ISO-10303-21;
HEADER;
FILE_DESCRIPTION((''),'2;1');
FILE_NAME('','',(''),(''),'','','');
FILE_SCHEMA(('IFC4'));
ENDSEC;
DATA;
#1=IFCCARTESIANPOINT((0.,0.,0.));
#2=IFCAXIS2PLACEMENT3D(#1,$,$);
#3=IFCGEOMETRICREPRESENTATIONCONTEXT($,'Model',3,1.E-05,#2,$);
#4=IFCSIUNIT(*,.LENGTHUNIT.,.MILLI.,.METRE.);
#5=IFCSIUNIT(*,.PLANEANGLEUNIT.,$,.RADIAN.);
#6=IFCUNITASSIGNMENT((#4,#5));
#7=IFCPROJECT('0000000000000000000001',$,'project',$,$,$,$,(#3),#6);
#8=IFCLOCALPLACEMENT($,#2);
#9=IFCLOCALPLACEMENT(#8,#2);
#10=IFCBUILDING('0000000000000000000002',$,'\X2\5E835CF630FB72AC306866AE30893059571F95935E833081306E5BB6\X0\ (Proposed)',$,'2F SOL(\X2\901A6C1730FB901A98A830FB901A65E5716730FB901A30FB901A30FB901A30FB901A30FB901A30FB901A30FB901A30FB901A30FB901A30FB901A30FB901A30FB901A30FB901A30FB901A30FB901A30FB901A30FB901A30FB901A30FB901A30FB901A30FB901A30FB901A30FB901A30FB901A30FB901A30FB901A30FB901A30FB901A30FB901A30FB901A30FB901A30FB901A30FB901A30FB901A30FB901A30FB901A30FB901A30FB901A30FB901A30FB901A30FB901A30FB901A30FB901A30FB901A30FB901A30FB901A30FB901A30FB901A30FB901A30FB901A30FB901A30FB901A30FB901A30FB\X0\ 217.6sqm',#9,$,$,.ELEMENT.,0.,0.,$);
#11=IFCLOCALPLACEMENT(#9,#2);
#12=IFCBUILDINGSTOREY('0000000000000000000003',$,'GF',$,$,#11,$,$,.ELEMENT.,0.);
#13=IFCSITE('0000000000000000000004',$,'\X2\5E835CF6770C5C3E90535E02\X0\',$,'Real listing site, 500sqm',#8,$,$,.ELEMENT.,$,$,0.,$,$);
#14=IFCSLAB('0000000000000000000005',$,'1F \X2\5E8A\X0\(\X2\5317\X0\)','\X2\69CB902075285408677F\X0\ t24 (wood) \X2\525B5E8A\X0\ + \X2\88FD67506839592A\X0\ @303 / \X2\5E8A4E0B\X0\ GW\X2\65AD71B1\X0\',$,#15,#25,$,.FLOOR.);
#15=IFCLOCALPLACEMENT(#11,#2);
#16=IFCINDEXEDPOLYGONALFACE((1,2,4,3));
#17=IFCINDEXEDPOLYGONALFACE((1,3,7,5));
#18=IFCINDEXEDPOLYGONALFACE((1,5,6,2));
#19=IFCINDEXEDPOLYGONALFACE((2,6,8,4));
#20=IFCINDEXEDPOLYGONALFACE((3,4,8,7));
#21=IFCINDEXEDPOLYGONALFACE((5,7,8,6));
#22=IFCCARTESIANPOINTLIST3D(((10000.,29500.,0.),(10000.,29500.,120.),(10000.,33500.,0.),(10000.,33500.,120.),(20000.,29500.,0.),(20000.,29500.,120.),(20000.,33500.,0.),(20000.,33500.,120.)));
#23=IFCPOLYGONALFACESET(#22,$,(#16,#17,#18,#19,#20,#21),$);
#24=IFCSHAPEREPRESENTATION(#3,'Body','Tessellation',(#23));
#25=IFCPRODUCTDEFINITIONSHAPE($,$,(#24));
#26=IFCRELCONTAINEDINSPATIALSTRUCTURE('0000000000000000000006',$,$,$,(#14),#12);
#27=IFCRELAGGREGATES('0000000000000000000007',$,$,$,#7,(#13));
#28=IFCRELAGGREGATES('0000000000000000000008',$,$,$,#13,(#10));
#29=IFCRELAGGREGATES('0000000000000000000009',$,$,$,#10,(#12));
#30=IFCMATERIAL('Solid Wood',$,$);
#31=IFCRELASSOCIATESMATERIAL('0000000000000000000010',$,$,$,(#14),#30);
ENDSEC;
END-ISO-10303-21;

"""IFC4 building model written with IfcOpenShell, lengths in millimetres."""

from ifc_helpers import new_model, si_unit, frame, frame_2d, origin, place, context, project, spatial, rectangle, extrude, material, element, save


model = new_model("IFC4")

# Units and contexts
model_context = context("Model", 3, precision=1e-05, world=origin())
ifc_project = project(units=[si_unit("LENGTHUNIT", "METRE", prefix="MILLI"), si_unit("PLANEANGLEUNIT", "RADIAN")], contexts=[model_context])

# Site, building, storey
site_placement = place(None, origin())
site = spatial("IfcSite", under=ifc_project, at=site_placement, Name="広島県尾道市", ObjectType="Real listing site, 500sqm", CompositionType="ELEMENT", RefElevation=0.0)
building_placement = place(site_placement, origin())
building = spatial("IfcBuilding", under=site, at=building_placement, Name="広島・犬と暮らす土間広めの家 (Proposed)", ObjectType="2F SOL(通気・通風・通日照・通・通・通・通・通・通・通・通・通・通・通・通・通・通・通・通・通・通・通・通・通・通・通・通・通・通・通・通・通・通・通・通・通・通・通・通・通・通・通・通・通・通・通・通・通・通・通・通・通・通・通・通・通・ 217.6sqm", CompositionType="ELEMENT", ElevationOfRefHeight=0.0, ElevationOfTerrain=0.0)
storey_placement = place(building_placement, origin())
storey = spatial("IfcBuildingStorey", under=building, at=storey_placement, Name="GF", CompositionType="ELEMENT", Elevation=0.0)

# Shared definitions
ifc_material_1 = material(Name="Solid Wood")

# Slab
slab_1_placement = place(storey_placement, frame((5000.0, 14750.0, 0.0)))
element("IfcSlab", 1, at=slab_1_placement, inside=storey, material=ifc_material_1, Name="1F 床(北)", Description="構造用合板 t24 (wood) 剛床 + 製材根太 @303 / 床下 GW断熱", PredefinedType="FLOOR", context=model_context, shape_type="SweptSolid", body=[
    extrude(rectangle(XDim=10000.0, YDim=4000.0, at=frame_2d((5000.0, 2000.0))), frame((5000.0, 14750.0, 0.0)), (0.0, 0.0, 1.0), 120.0),
])

save(model, "model.ifc")
